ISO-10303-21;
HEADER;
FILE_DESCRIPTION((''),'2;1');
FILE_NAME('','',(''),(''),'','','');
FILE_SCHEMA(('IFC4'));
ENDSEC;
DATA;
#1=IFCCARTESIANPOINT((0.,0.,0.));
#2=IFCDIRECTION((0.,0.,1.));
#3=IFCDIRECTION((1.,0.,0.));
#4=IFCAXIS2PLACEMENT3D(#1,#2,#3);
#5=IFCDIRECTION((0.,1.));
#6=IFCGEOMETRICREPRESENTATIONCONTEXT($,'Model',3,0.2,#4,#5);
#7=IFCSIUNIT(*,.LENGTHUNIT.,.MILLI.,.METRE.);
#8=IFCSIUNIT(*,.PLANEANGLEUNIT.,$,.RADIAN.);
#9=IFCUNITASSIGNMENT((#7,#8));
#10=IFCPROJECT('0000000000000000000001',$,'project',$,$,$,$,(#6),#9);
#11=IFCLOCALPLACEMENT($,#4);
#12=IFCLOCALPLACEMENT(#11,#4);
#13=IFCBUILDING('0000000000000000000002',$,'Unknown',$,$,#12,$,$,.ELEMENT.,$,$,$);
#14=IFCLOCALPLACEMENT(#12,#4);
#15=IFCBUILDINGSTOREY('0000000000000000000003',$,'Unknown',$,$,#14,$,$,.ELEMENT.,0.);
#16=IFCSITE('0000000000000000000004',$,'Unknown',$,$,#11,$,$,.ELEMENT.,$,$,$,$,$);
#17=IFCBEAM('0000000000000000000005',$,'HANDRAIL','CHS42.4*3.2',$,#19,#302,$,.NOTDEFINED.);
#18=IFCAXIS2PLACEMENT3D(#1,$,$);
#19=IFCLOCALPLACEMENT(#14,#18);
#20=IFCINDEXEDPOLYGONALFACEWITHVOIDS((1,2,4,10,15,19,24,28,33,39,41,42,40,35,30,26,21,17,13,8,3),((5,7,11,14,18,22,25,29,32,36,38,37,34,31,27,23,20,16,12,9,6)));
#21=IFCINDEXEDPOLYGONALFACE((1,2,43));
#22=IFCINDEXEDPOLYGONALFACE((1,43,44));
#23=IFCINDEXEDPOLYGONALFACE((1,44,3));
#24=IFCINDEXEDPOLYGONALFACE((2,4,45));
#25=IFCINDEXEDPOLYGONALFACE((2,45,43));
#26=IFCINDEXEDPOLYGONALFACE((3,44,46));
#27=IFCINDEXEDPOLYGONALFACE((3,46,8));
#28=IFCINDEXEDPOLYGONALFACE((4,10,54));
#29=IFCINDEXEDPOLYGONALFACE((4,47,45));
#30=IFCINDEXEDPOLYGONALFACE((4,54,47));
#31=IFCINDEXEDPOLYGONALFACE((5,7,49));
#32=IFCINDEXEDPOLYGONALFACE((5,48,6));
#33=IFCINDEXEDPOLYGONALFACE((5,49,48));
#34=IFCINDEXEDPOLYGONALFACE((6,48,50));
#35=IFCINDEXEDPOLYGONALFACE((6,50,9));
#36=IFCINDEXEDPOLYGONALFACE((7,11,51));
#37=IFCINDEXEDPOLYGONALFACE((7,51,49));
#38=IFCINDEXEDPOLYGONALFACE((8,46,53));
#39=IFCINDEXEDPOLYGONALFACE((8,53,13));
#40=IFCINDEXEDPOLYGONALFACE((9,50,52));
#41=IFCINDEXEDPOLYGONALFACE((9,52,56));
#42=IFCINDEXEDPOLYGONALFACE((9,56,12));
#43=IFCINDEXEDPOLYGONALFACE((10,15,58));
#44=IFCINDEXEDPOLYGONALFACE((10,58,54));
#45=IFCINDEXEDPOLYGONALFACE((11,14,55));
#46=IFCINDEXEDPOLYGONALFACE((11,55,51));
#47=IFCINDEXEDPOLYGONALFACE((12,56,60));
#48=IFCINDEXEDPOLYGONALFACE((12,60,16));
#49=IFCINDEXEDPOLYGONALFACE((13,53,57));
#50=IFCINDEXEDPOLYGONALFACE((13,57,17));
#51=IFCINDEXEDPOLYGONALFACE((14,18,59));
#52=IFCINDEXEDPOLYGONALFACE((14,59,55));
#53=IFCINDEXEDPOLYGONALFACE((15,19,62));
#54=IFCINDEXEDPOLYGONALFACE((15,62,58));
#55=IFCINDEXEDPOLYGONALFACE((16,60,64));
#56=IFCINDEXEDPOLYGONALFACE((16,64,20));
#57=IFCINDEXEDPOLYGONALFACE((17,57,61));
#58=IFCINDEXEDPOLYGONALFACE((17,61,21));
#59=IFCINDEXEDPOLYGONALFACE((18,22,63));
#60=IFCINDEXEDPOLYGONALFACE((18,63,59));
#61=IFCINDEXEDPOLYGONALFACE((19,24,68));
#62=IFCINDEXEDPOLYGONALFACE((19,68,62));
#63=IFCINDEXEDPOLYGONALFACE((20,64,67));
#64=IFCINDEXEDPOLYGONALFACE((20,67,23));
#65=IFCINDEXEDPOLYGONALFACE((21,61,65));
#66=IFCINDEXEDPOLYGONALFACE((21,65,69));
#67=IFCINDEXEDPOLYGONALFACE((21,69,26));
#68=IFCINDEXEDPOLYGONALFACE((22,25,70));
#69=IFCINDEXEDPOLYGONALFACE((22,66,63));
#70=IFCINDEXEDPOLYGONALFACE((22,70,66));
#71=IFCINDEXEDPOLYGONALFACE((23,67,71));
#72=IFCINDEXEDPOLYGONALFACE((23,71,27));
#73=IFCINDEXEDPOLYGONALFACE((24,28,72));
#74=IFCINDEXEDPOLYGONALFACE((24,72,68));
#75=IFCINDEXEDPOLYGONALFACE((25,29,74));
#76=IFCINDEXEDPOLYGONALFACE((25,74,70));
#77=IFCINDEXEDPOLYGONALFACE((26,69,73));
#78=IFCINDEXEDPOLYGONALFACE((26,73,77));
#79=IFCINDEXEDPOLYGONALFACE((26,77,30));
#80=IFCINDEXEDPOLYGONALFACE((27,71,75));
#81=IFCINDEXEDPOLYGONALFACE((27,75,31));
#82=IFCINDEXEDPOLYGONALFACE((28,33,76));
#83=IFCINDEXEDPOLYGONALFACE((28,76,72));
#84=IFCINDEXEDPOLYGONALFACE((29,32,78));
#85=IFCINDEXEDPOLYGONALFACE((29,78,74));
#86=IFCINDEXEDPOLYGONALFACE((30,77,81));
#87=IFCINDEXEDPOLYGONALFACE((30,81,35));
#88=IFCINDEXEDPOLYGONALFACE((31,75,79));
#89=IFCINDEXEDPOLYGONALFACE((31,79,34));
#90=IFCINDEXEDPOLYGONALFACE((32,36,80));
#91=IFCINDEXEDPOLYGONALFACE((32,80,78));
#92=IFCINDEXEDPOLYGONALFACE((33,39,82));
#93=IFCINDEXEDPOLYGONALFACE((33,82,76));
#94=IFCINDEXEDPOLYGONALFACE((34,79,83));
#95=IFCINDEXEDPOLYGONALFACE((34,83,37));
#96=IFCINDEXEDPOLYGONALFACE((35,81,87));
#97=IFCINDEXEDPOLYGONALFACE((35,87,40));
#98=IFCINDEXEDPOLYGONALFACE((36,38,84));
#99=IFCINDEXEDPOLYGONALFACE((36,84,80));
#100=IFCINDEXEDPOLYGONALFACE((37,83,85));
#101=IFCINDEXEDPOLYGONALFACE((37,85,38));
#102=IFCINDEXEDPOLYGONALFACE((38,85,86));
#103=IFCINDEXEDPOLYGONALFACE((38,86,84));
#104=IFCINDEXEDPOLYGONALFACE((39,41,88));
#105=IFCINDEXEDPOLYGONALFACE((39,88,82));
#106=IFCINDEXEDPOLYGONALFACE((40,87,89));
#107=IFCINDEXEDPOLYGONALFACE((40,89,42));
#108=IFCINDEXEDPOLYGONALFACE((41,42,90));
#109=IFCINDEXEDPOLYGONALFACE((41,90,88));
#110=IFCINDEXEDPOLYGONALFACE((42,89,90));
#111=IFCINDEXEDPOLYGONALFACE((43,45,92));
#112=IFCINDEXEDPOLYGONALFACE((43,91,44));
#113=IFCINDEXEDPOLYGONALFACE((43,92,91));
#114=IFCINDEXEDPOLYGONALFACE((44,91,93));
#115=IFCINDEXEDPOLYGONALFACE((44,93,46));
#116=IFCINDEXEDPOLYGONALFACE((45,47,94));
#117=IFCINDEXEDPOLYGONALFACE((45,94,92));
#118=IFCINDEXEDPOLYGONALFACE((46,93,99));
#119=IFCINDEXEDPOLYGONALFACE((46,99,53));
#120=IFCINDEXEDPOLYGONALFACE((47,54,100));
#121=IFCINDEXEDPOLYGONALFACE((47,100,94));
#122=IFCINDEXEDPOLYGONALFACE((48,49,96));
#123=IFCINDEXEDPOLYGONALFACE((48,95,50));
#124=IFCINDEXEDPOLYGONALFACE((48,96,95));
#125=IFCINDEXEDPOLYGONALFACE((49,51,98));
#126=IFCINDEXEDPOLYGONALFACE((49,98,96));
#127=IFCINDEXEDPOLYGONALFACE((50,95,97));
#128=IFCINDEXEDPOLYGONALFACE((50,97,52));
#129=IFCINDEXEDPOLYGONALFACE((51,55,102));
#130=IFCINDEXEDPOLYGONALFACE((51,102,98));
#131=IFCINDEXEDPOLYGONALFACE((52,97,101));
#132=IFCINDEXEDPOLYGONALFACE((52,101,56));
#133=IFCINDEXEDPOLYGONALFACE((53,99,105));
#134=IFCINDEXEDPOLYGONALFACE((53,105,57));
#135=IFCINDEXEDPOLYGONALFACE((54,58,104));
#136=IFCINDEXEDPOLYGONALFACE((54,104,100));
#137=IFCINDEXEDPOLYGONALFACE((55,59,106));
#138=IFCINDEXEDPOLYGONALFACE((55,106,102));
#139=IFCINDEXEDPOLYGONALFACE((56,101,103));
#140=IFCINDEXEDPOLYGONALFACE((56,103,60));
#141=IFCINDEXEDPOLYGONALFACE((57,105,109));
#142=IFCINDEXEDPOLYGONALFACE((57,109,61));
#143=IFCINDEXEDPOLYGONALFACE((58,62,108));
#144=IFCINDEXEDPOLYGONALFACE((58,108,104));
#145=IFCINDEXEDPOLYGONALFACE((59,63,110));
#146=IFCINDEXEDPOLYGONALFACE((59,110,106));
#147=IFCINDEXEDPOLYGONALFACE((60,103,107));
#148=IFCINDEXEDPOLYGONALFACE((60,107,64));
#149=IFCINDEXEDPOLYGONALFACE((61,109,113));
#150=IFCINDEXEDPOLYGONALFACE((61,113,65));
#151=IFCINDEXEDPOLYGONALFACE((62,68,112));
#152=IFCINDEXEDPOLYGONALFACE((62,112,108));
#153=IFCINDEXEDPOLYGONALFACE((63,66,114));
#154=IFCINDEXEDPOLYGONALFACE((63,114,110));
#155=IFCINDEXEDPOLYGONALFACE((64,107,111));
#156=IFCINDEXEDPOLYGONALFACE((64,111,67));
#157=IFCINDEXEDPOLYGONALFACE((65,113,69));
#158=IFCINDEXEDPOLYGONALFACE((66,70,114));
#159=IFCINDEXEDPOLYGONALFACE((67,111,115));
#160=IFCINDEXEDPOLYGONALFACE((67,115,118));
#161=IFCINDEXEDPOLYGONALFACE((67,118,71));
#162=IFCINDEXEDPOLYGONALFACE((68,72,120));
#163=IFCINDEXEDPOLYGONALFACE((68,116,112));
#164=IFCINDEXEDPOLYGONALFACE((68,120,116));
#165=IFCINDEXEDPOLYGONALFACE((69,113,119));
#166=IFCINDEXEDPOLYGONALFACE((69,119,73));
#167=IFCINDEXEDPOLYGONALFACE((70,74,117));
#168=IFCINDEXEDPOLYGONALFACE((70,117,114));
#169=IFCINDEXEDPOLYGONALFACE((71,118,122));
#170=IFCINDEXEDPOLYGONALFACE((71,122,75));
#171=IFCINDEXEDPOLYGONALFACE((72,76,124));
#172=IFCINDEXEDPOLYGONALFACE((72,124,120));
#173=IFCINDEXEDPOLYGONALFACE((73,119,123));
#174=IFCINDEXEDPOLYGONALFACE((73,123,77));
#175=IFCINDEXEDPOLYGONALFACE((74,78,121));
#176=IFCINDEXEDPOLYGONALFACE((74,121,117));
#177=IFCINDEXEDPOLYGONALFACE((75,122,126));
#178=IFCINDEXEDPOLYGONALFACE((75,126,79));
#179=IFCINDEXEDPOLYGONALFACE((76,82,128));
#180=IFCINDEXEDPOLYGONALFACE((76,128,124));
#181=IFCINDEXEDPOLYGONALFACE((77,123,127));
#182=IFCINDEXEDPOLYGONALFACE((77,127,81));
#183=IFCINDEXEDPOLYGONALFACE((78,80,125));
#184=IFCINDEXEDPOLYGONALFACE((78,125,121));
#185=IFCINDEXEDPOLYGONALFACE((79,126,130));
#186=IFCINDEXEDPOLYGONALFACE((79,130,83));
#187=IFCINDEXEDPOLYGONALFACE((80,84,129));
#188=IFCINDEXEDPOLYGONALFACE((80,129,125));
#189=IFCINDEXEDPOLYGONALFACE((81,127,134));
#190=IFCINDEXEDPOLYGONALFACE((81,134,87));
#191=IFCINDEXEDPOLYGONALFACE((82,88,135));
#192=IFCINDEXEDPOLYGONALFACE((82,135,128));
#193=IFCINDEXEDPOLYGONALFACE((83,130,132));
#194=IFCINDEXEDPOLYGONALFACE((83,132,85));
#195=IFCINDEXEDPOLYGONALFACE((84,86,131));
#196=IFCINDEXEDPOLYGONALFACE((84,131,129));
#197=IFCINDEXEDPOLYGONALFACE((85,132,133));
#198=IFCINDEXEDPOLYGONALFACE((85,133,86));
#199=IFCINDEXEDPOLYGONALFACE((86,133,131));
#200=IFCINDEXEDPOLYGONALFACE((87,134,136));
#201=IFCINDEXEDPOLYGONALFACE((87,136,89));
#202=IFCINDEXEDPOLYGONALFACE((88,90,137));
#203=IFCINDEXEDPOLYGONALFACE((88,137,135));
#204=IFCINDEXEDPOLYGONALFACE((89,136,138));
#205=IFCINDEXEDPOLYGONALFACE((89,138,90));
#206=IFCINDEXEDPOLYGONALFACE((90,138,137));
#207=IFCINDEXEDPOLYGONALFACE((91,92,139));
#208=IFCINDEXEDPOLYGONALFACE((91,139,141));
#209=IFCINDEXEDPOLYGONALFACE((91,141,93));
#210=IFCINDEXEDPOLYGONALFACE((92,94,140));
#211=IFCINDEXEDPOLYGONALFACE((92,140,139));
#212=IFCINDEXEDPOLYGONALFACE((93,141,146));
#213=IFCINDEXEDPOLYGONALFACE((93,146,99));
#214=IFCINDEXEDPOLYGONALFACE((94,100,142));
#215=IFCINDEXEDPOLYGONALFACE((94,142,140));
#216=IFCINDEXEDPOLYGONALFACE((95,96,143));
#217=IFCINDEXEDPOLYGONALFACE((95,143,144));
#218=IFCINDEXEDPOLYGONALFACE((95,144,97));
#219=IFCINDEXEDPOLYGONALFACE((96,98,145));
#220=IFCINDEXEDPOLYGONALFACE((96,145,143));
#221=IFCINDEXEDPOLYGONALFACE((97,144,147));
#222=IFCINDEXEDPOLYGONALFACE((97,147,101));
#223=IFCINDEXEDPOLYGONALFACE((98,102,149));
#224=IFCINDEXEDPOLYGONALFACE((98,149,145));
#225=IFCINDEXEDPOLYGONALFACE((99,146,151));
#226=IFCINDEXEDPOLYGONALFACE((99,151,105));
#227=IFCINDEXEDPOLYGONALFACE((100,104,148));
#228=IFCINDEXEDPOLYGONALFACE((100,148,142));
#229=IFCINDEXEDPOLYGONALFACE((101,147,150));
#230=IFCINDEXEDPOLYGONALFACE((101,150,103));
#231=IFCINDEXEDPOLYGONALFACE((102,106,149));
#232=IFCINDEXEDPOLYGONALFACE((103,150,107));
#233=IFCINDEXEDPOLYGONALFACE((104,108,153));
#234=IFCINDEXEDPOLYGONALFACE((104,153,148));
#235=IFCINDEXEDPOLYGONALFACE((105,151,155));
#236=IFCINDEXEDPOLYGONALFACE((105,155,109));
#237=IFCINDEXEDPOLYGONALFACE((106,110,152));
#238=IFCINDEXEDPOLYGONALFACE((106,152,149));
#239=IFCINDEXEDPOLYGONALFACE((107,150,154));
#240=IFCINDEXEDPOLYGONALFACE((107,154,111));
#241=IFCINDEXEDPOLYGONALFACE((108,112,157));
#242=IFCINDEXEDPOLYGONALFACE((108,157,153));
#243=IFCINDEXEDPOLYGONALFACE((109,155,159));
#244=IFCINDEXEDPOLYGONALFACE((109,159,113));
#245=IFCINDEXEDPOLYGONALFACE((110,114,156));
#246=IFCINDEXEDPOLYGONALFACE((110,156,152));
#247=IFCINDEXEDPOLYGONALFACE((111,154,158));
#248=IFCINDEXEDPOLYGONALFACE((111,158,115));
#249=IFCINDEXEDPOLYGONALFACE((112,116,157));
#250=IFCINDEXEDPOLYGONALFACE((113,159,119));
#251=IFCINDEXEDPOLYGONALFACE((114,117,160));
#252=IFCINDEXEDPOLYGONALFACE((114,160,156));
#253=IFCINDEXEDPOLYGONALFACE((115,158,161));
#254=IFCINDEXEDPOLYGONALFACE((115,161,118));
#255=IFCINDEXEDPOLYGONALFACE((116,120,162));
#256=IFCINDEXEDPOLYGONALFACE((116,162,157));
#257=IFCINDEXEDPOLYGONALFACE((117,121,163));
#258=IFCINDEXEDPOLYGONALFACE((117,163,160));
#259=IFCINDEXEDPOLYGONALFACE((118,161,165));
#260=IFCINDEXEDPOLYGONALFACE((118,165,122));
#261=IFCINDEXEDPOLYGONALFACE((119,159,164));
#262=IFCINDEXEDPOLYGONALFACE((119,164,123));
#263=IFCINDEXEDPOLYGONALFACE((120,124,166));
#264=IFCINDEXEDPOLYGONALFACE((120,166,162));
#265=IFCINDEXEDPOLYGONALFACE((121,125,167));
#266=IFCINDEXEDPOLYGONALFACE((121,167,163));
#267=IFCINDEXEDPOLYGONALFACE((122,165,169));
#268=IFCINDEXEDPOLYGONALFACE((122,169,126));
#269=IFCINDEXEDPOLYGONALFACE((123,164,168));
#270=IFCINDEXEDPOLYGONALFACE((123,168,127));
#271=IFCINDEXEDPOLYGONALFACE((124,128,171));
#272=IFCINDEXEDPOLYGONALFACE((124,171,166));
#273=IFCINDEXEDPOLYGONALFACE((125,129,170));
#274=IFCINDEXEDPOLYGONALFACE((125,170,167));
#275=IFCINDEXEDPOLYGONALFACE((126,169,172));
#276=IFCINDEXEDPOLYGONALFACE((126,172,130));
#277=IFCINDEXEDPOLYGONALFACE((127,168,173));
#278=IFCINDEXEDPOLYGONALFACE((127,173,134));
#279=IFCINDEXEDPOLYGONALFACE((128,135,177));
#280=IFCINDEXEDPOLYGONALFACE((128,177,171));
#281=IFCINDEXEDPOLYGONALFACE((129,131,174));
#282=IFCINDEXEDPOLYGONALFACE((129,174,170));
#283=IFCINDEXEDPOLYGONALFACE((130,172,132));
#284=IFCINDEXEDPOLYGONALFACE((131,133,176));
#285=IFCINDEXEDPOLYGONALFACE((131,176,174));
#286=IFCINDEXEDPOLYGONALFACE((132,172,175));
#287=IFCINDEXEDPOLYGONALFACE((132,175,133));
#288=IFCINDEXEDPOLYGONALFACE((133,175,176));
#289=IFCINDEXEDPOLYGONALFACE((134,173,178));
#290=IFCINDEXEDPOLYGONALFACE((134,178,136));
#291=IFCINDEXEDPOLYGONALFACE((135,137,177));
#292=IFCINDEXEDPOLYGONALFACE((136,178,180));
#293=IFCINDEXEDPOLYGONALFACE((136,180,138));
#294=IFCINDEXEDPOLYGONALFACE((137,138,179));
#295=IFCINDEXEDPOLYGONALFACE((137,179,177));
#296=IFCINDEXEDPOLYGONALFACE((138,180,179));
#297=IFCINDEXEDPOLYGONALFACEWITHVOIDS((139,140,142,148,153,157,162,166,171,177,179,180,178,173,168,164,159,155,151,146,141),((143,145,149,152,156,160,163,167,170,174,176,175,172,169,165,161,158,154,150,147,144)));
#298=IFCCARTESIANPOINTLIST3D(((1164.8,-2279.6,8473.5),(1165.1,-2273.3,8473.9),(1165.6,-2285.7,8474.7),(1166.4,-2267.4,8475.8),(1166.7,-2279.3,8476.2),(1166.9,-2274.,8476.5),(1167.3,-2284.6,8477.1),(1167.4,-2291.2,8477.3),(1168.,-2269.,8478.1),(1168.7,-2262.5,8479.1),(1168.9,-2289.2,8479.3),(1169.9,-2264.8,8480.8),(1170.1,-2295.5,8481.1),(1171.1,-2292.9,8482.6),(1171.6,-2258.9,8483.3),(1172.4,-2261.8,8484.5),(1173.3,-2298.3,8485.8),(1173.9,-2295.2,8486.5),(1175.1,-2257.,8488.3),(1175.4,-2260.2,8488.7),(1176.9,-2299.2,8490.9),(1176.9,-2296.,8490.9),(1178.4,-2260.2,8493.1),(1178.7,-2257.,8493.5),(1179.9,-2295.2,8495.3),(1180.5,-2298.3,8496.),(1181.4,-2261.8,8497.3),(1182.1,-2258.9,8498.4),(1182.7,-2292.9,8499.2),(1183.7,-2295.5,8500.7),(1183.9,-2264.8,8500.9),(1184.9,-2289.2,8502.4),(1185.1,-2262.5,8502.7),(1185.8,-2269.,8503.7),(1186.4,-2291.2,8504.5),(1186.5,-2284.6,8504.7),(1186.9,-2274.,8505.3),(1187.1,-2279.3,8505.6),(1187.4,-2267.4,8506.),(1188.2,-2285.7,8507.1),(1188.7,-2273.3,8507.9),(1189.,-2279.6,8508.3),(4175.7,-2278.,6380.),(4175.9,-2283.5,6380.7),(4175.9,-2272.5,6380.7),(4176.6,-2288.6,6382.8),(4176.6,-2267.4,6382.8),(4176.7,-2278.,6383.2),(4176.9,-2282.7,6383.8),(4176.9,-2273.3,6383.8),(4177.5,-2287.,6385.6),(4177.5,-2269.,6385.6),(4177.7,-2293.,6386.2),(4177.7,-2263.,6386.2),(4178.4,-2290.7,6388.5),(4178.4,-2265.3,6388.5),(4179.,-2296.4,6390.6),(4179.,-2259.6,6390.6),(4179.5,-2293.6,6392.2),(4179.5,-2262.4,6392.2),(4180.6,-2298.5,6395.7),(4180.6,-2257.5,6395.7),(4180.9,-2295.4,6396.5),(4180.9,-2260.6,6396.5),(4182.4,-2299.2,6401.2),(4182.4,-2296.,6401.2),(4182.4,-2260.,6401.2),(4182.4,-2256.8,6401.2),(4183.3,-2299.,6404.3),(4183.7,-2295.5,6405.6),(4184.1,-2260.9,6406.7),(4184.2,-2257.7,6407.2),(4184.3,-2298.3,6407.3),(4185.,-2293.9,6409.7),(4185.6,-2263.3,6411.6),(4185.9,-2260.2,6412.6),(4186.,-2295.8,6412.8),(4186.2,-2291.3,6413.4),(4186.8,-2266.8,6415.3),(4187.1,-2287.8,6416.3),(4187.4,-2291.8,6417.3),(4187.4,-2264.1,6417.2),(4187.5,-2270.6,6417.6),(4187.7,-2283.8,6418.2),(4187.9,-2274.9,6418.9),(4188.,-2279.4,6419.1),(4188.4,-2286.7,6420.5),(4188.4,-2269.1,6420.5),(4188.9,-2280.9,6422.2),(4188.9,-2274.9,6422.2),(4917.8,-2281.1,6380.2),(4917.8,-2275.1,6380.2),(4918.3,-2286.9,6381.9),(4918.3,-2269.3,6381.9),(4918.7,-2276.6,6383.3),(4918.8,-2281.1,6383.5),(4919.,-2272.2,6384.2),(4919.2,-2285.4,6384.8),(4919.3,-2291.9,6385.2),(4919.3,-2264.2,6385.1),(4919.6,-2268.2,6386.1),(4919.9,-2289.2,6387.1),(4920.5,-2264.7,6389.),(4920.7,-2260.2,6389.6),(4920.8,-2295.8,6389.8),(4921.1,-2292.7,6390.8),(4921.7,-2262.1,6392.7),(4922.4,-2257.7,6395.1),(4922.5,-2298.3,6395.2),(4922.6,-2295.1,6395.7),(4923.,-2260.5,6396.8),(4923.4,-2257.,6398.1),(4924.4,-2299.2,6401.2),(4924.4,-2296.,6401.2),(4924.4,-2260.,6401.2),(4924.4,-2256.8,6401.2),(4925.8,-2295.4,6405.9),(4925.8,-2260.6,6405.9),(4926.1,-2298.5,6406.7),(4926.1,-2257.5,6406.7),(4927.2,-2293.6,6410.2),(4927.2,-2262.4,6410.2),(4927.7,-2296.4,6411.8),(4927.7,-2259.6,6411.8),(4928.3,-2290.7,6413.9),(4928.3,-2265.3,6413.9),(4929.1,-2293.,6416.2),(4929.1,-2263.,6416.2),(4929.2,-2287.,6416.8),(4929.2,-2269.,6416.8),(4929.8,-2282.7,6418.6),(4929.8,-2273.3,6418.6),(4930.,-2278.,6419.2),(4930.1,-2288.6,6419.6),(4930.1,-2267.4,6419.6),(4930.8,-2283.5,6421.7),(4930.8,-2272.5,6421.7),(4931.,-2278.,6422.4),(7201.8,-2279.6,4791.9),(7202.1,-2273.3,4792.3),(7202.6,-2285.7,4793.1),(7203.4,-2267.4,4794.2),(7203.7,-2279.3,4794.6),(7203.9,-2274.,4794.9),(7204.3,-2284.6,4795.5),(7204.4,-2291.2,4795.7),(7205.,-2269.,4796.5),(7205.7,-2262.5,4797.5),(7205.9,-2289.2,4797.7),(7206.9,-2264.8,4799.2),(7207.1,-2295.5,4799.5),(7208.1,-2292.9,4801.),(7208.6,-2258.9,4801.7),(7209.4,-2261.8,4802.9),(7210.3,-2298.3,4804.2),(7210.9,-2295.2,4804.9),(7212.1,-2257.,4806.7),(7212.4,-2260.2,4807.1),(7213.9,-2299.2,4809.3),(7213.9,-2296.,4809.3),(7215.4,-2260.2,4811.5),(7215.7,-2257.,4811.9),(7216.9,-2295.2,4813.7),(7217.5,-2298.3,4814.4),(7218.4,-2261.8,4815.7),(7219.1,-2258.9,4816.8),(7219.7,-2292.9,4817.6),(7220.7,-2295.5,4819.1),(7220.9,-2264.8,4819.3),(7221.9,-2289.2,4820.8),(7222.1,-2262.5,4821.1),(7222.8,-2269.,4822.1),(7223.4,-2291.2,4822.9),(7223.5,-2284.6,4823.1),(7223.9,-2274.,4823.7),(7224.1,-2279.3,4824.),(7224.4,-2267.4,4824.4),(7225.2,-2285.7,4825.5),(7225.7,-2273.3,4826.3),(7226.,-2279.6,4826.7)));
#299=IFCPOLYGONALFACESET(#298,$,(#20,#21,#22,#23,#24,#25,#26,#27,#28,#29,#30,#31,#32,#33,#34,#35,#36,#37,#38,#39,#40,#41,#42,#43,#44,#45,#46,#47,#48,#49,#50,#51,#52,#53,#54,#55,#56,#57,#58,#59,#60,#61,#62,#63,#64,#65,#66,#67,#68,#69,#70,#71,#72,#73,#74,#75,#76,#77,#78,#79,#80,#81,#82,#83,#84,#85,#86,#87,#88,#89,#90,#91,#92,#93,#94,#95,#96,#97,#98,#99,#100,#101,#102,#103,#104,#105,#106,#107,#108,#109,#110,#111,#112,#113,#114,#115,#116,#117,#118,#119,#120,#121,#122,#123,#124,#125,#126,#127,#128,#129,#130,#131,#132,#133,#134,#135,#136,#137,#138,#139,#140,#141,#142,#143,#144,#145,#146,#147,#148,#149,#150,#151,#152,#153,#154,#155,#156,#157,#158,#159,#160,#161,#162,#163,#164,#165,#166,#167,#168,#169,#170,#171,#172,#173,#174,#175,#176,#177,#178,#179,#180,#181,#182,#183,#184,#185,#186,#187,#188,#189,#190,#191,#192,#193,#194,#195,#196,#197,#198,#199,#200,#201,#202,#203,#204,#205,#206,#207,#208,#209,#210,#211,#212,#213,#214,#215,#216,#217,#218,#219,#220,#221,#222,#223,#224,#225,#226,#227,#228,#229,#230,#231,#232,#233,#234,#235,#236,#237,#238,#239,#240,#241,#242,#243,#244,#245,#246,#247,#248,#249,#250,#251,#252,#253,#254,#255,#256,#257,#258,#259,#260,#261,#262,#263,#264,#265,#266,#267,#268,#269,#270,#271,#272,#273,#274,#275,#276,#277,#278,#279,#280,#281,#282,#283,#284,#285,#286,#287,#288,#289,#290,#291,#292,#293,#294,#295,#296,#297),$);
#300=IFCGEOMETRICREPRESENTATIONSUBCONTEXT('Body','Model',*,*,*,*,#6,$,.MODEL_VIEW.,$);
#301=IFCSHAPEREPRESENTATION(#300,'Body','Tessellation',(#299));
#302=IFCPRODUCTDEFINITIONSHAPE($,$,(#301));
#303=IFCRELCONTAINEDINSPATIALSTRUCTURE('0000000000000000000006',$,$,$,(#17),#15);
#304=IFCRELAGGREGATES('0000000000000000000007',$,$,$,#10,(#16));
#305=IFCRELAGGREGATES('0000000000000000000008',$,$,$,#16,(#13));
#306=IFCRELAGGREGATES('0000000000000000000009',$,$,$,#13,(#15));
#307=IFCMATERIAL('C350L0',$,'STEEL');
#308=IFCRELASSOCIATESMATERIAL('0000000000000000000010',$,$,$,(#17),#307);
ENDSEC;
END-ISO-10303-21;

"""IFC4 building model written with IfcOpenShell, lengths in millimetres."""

from ifc_helpers import new_model, entity, si_unit, direction, frame, origin_with_axes, place, context, subcontext, project, spatial, material, element, save


model = new_model("IFC4")

# Units and contexts
model_context = context("Model", 3, precision=0.2, world=origin_with_axes(), true_north=direction((0.0, 1.0)))
body_context = subcontext(model_context, "Body", "Model", "MODEL_VIEW")
ifc_project = project(units=[si_unit("LENGTHUNIT", "METRE", prefix="MILLI"), si_unit("PLANEANGLEUNIT", "RADIAN")], contexts=[model_context])

# Site, building, storey
site_placement = place(None, origin_with_axes())
site = spatial("IfcSite", under=ifc_project, at=site_placement, Name="Unknown", CompositionType="ELEMENT")
building_placement = place(site_placement, origin_with_axes())
building = spatial("IfcBuilding", under=site, at=building_placement, Name="Unknown", CompositionType="ELEMENT")
storey_placement = place(building_placement, origin_with_axes())
storey = spatial("IfcBuildingStorey", under=building, at=storey_placement, Name="Unknown", CompositionType="ELEMENT", Elevation=0.0)

# Shared definitions
ifc_material_1 = material(Name="C350L0", Category="STEEL")

# Beam
for number, where, z_axis, x_axis, name in (
    (1, (1176.9, -2278.0, 8490.9), (0.0, -1.0, 0.0), (0.821041, 0.0, -0.57087), "HANDRAIL"),
):
    element("IfcBeam", number, at=place(storey_placement, frame(where, z_axis=z_axis, x_axis=x_axis)), inside=storey, material=ifc_material_1, Name=name, Description="CHS42.4*3.2", PredefinedType="NOTDEFINED", context=body_context, shape_type="SolidModel", body=[
        entity("IfcSweptDiskSolid", entity("IfcIndexedPolyCurve", entity("IfcCartesianPointList3D", [[0.0, 0.0, 0.0], [3660.5, 0.0, 0.0], [4269.8, 423.6, 0.0], [7058.3, 423.6, 0.0]]), [entity("IfcLineIndex", [1, 2, 3, 4])]), 21.2, 18.0),
    ])

save(model, "model.ifc")
